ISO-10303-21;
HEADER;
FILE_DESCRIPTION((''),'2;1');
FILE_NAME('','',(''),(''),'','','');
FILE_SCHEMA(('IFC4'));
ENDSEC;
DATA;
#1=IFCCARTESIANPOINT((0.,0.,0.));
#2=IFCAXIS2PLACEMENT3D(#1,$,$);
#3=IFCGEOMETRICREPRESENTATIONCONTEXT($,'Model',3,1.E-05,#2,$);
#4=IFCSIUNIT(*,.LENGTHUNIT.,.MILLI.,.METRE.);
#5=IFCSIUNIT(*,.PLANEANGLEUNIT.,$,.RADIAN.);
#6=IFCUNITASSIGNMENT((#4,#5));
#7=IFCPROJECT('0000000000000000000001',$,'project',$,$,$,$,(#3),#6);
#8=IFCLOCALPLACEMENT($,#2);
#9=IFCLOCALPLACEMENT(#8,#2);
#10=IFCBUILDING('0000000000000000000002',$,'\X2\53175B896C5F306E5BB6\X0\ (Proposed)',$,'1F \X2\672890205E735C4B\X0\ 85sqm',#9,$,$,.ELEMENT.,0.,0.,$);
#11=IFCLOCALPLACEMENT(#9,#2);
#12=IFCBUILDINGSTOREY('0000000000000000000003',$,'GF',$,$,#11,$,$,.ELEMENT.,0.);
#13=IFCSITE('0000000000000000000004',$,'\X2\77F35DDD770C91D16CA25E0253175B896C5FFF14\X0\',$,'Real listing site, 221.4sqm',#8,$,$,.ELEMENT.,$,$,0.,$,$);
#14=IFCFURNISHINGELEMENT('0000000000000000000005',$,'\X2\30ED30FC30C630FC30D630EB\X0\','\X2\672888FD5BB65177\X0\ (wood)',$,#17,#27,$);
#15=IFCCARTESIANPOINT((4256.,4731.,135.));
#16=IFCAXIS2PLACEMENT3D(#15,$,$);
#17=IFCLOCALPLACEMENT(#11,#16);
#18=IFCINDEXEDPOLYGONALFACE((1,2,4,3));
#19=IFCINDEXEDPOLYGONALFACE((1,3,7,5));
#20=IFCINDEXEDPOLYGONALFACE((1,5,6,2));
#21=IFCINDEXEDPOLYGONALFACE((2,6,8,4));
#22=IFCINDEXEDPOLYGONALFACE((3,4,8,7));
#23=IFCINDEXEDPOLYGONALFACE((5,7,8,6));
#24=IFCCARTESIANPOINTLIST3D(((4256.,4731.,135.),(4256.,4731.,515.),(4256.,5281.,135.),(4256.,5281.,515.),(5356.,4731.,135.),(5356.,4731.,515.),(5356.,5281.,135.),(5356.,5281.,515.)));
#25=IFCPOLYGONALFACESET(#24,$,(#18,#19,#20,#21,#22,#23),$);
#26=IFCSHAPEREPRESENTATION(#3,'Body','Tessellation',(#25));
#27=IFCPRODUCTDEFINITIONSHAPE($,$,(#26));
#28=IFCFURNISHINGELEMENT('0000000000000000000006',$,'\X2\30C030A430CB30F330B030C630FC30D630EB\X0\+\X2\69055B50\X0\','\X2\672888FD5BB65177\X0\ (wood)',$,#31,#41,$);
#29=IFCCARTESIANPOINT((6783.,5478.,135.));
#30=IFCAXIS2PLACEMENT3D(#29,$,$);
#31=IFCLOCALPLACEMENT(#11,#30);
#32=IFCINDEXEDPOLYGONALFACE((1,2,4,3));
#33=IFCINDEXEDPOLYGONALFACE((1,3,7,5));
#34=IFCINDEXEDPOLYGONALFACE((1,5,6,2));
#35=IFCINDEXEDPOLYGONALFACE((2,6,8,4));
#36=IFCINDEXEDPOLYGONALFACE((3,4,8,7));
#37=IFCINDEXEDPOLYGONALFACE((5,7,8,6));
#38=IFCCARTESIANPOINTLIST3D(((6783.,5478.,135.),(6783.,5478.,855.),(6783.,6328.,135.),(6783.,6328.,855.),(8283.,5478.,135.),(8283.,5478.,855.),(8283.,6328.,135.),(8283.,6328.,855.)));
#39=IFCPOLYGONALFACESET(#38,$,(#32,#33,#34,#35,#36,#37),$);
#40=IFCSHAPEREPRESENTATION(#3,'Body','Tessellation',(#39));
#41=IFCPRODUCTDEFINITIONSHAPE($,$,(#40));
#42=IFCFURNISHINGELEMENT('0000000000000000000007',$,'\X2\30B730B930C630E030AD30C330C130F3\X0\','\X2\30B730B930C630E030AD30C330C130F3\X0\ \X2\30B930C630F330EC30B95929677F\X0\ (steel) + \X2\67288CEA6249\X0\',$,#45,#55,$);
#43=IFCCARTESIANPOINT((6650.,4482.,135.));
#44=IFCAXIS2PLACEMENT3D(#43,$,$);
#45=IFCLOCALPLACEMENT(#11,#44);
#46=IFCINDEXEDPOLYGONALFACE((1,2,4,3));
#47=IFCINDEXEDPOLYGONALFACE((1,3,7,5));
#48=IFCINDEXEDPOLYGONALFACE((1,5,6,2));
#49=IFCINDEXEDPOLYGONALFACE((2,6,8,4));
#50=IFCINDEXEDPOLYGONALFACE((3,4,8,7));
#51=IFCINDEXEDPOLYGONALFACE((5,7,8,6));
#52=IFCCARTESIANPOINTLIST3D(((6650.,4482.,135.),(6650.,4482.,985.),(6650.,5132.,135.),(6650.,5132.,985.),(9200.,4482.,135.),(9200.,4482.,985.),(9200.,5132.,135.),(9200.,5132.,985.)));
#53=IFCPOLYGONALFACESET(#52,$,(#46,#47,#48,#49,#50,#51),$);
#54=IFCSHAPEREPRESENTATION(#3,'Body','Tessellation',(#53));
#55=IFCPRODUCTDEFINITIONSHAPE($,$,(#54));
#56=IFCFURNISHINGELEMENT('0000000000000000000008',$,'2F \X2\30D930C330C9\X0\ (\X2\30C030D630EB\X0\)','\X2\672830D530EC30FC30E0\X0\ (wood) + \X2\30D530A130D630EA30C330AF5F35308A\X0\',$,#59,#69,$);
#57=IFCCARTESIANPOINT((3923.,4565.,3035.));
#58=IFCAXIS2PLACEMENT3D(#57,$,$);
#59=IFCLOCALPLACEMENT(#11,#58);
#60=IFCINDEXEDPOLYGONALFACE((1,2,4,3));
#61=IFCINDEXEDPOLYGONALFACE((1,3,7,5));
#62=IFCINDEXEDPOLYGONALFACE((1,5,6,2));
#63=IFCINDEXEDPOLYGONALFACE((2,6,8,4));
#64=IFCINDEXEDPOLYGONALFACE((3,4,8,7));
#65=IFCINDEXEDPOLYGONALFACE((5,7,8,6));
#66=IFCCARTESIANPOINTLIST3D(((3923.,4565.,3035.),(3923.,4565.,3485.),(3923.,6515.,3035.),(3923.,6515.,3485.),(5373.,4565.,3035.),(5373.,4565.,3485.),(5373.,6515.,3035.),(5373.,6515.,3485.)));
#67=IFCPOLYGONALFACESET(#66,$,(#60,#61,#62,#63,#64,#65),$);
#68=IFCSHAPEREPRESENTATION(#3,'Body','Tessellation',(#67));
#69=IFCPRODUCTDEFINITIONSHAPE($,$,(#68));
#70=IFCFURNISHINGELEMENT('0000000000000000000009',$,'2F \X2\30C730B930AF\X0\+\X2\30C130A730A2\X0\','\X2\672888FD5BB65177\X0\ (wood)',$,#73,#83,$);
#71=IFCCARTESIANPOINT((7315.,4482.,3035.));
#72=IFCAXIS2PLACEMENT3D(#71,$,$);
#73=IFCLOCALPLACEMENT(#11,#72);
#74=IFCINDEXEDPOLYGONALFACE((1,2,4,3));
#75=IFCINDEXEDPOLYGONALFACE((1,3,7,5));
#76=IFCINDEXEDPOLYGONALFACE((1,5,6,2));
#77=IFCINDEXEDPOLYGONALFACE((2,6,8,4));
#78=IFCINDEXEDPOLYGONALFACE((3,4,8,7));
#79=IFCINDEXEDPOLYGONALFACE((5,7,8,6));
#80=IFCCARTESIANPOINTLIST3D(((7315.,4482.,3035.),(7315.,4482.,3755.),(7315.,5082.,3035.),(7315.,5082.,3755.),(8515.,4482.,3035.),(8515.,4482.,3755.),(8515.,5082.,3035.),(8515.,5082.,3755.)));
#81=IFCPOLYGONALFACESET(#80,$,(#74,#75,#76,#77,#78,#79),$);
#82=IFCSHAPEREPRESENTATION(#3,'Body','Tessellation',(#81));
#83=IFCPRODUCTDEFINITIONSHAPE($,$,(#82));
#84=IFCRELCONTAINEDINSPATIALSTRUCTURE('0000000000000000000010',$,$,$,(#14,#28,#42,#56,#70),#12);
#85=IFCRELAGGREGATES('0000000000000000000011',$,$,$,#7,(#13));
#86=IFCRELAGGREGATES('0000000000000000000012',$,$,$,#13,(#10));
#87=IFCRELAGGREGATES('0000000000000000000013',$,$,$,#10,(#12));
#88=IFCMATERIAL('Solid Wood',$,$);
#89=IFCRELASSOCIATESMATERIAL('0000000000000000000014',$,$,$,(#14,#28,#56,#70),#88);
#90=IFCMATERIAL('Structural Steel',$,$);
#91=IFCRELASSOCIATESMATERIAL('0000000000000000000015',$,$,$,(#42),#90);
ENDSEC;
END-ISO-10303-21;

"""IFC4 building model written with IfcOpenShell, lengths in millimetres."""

from ifc_helpers import new_model, si_unit, frame, frame_2d, origin, place, context, project, spatial, rectangle, extrude, material, element, save


model = new_model("IFC4")

# Units and contexts
model_context = context("Model", 3, precision=1e-05, world=origin())
ifc_project = project(units=[si_unit("LENGTHUNIT", "METRE", prefix="MILLI"), si_unit("PLANEANGLEUNIT", "RADIAN")], contexts=[model_context])

# Site, building, storey
site_placement = place(None, origin())
site = spatial("IfcSite", under=ifc_project, at=site_placement, Name="石川県金沢市北安江４", ObjectType="Real listing site, 221.4sqm", CompositionType="ELEMENT", RefElevation=0.0)
building_placement = place(site_placement, origin())
building = spatial("IfcBuilding", under=site, at=building_placement, Name="北安江の家 (Proposed)", ObjectType="1F 木造平屋 85sqm", CompositionType="ELEMENT", ElevationOfRefHeight=0.0, ElevationOfTerrain=0.0)
storey_placement = place(building_placement, origin())
storey = spatial("IfcBuildingStorey", under=building, at=storey_placement, Name="GF", CompositionType="ELEMENT", Elevation=0.0)

# Shared definitions
ifc_material_1 = material(Name="Solid Wood")

# Shared definitions
ifc_material_2 = material(Name="Structural Steel")

# Furnishing elements
furnishing_1_placement = place(storey_placement, frame((4256.0, 4731.0, 135.0)))
element("IfcFurnishingElement", 1, at=furnishing_1_placement, inside=storey, material=ifc_material_1, Name="ローテーブル", Description="木製家具 (wood)", context=model_context, shape_type="SweptSolid", body=[
    extrude(rectangle(XDim=1100.0, YDim=550.0, at=frame_2d((550.0, 275.0))), frame((4256.0, 4731.0, 135.0)), (0.0, 0.0, 1.0), 380.0),
])
furnishing_2_placement = place(storey_placement, frame((6783.0, 5478.0, 135.0)))
element("IfcFurnishingElement", 2, at=furnishing_2_placement, inside=storey, material=ifc_material_1, Name="ダイニングテーブル+椅子", Description="木製家具 (wood)", context=model_context, shape_type="SweptSolid", body=[
    extrude(rectangle(XDim=1500.0, YDim=850.0, at=frame_2d((750.0, 425.0))), frame((6783.0, 5478.0, 135.0)), (0.0, 0.0, 1.0), 720.0),
])
furnishing_3_placement = place(storey_placement, frame((6650.0, 4482.0, 135.0)))
element("IfcFurnishingElement", 3, at=furnishing_3_placement, inside=storey, material=ifc_material_2, Name="システムキッチン", Description="システムキッチン ステンレス天板 (steel) + 木質扉", context=model_context, shape_type="SweptSolid", body=[
    extrude(rectangle(XDim=2550.0, YDim=650.0, at=frame_2d((1275.0, 325.0))), frame((6650.0, 4482.0, 135.0)), (0.0, 0.0, 1.0), 850.0),
])
furnishing_4_placement = place(storey_placement, frame((3923.0, 4565.0, 3035.0)))
element("IfcFurnishingElement", 4, at=furnishing_4_placement, inside=storey, material=ifc_material_1, Name="2F ベッド (ダブル)", Description="木フレーム (wood) + ファブリック張り", context=model_context, shape_type="SweptSolid", body=[
    extrude(rectangle(XDim=1450.0, YDim=1950.0, at=frame_2d((725.0, 975.0))), frame((3923.0, 4565.0, 3035.0)), (0.0, 0.0, 1.0), 450.0),
])
furnishing_5_placement = place(storey_placement, frame((7315.0, 4482.0, 3035.0)))
element("IfcFurnishingElement", 5, at=furnishing_5_placement, inside=storey, material=ifc_material_1, Name="2F デスク+チェア", Description="木製家具 (wood)", context=model_context, shape_type="SweptSolid", body=[
    extrude(rectangle(XDim=1200.0, YDim=600.0, at=frame_2d((600.0, 300.0))), frame((7315.0, 4482.0, 3035.0)), (0.0, 0.0, 1.0), 720.0),
])

save(model, "model.ifc")
